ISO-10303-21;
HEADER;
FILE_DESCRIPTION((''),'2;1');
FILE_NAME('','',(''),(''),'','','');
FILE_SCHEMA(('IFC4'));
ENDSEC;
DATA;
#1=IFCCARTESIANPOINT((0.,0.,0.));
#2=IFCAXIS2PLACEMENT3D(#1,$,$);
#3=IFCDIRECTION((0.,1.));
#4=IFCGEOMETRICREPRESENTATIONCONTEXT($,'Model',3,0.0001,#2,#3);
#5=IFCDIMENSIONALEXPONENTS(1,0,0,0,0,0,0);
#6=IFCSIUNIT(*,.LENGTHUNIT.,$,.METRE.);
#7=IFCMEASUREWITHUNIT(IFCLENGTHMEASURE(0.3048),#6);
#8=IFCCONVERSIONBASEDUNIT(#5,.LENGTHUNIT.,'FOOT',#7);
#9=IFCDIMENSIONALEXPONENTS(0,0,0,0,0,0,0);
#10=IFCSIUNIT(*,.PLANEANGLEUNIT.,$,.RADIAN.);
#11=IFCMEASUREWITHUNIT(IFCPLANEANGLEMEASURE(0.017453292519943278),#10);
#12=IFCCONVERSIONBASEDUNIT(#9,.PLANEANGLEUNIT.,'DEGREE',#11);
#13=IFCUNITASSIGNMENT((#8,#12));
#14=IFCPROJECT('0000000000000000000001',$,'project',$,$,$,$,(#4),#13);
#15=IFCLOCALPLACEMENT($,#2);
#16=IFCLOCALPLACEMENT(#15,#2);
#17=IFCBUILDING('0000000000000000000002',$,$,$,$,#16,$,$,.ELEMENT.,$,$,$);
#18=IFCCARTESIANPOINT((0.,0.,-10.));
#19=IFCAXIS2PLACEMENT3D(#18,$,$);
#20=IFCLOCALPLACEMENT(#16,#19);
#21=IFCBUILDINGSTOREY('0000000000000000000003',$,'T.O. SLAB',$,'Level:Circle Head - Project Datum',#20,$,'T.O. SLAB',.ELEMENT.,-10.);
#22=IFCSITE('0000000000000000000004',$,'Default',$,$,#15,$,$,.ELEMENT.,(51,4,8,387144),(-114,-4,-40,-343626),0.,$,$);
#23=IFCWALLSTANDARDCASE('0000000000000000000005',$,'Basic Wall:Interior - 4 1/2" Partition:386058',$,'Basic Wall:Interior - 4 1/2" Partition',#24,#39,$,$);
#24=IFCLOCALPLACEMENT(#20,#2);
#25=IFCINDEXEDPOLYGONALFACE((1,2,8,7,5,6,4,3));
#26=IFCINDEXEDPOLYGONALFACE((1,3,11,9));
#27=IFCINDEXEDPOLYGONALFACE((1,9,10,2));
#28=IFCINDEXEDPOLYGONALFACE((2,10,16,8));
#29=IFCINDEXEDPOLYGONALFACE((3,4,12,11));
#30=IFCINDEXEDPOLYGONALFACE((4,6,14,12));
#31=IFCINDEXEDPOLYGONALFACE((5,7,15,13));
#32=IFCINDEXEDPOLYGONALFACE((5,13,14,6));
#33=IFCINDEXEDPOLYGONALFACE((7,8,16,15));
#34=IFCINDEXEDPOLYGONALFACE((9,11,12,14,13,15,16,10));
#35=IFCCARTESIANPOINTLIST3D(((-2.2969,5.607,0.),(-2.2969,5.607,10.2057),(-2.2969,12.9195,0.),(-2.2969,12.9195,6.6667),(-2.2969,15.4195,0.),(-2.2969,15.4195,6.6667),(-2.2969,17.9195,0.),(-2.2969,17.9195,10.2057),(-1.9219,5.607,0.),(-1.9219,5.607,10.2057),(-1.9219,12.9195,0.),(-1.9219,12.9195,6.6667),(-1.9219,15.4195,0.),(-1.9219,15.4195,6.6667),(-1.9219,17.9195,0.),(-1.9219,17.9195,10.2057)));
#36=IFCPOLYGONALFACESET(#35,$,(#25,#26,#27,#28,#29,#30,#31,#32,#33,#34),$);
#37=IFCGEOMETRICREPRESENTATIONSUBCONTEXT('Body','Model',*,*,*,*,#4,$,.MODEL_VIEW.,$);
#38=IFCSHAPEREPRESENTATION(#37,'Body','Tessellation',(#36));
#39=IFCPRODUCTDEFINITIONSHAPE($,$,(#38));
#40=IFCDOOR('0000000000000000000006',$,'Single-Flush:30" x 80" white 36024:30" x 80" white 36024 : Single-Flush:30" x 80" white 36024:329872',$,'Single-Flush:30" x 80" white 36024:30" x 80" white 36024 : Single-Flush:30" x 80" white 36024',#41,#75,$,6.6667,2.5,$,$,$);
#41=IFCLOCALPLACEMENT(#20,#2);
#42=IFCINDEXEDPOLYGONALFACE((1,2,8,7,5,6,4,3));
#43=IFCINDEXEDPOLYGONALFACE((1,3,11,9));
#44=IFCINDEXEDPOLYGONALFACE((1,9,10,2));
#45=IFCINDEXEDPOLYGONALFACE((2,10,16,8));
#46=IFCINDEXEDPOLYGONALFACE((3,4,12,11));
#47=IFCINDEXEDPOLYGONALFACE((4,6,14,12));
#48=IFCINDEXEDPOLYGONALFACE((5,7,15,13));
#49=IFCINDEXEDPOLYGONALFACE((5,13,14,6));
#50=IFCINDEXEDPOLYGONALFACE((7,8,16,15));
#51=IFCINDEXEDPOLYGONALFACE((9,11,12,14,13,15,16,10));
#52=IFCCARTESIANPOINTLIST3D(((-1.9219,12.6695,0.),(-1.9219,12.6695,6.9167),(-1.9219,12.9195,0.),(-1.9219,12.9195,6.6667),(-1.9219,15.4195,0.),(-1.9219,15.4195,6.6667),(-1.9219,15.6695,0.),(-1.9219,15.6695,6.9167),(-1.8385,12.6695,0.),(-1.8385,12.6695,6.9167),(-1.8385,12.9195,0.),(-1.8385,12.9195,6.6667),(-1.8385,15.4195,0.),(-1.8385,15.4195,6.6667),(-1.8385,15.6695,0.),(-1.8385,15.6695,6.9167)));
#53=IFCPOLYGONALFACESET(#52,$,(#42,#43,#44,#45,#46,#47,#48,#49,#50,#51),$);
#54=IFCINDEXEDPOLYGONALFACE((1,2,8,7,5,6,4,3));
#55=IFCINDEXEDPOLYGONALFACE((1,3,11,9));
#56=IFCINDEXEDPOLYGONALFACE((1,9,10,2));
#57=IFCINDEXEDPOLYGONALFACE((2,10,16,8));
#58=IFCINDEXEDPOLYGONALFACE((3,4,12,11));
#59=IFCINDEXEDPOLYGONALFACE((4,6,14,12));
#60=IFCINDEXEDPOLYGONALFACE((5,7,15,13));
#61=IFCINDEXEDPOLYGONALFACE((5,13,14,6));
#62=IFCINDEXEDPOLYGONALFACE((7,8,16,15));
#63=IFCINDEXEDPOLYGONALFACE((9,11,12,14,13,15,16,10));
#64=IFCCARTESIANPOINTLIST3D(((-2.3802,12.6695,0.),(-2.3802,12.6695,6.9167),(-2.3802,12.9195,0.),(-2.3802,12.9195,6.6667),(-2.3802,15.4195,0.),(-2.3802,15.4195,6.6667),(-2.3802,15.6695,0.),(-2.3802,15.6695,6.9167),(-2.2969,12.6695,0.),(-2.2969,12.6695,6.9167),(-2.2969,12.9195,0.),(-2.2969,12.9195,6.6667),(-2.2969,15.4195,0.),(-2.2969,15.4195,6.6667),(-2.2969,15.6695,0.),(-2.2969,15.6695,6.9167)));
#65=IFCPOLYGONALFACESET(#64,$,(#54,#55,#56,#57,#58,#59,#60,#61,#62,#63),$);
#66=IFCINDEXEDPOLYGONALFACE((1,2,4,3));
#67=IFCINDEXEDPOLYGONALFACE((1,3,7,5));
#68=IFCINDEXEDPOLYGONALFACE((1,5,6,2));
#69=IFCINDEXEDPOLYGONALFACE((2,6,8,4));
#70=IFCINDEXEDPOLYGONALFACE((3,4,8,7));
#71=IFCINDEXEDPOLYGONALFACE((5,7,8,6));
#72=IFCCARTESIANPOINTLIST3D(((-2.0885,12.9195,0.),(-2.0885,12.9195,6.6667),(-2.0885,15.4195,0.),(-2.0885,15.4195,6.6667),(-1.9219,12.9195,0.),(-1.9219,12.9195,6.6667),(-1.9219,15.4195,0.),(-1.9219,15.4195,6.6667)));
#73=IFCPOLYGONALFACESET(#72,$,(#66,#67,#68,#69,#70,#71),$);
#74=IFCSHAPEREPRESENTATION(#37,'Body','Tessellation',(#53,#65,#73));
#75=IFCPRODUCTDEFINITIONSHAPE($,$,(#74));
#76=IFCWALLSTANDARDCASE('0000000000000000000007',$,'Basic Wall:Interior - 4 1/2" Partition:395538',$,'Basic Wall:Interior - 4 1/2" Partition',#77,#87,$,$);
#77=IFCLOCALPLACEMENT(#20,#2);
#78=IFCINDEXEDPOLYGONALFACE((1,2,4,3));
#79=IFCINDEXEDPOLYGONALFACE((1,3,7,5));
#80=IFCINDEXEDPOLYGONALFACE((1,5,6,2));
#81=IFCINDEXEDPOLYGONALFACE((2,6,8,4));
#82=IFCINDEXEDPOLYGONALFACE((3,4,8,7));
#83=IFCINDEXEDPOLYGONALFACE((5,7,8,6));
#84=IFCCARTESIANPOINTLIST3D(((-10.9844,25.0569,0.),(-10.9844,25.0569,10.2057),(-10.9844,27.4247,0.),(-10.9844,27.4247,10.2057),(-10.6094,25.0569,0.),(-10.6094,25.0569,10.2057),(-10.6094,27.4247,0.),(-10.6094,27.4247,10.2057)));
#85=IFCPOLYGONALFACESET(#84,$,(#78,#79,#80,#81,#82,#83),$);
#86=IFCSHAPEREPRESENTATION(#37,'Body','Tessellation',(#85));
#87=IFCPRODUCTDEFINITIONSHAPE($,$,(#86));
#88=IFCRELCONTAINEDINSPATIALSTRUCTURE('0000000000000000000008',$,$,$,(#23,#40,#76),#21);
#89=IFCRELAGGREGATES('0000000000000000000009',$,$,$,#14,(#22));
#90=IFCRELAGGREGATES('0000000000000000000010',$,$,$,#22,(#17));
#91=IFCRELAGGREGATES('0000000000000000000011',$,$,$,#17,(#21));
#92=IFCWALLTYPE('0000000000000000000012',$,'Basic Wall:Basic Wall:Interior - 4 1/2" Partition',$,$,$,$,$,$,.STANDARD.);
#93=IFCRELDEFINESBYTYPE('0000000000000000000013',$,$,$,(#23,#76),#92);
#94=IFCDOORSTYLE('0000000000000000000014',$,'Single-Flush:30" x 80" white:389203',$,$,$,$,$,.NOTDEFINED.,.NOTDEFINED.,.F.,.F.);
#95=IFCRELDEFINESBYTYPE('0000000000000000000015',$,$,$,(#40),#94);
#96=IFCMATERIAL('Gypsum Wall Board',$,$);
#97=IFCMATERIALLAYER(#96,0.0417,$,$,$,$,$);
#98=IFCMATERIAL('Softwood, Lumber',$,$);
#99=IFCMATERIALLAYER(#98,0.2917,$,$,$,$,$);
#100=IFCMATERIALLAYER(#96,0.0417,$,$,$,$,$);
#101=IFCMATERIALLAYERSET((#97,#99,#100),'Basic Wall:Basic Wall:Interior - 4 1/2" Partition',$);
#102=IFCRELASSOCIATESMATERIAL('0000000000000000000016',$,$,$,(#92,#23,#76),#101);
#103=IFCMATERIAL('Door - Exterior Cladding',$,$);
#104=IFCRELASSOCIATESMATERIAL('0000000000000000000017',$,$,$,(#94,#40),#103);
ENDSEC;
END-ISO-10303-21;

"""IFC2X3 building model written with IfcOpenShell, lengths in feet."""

from ifc_helpers import new_model, entity, si_unit, converted_unit, direction, frame, frame_2d, origin, origin_2d_with_axis, place, context, subcontext, project, spatial, polyline, rectangle, outline, extrude, source, transform, mapped, material, layer, layer_set, layer_usage, type_object, type_shapes, element, fill, save


model = new_model("IFC2X3")

# Units and contexts
model_context = context("Model", 3, precision=0.0001, world=origin(), true_north=direction((0.0, 1.0)))
body_context = subcontext(model_context, "Body", "Model", "MODEL_VIEW")
ifc_project = project(units=[converted_unit("LENGTHUNIT", "FOOT", entity("IfcLengthMeasure", 0.3048), si_unit("LENGTHUNIT", "METRE"), dimensions=[1, 0, 0, 0, 0, 0, 0]), converted_unit("PLANEANGLEUNIT", "DEGREE", entity("IfcPlaneAngleMeasure", 0.017453292519943278), si_unit("PLANEANGLEUNIT", "RADIAN"), dimensions=[0, 0, 0, 0, 0, 0, 0])], contexts=[model_context])

# Site, building, storey
site_placement = place(None, origin())
site = spatial("IfcSite", under=ifc_project, at=site_placement, Name="Default", CompositionType="ELEMENT", RefLatitude=(51, 4, 8, 387144), RefLongitude=(-114, -4, -40, -343626), RefElevation=0.0)
building_placement = place(site_placement, origin())
building = spatial("IfcBuilding", under=site, at=building_placement, CompositionType="ELEMENT")
storey_placement = place(building_placement, frame((0.0, 0.0, -10.0)))
storey = spatial("IfcBuildingStorey", under=building, at=storey_placement, Name="T.O. SLAB", ObjectType="Level:Circle Head - Project Datum", LongName="T.O. SLAB", CompositionType="ELEMENT", Elevation=-10.0)

# Shared definitions
ifc_material_1 = material(Name="Gypsum Wall Board")
ifc_layer_1 = layer(ifc_material_1, 0.0417)
ifc_material_2 = material(Name="Softwood, Lumber")
ifc_layer_2 = layer(ifc_material_2, 0.2917)
ifc_layer_3 = layer(ifc_material_1, 0.0417)
ifc_layer_set_1 = layer_set([ifc_layer_1, ifc_layer_2, ifc_layer_3], Name="Basic Wall:Basic Wall:Interior - 4 1/2\" Partition")
wall_type_1 = type_object("IfcWallType", Name="Basic Wall:Basic Wall:Interior - 4 1/2\" Partition", PredefinedType="STANDARD", material=ifc_layer_set_1)
ifc_material_3 = material(Name="Door - Exterior Cladding")

# Wall, opening, door
ifc_layer_usage_1 = layer_usage(ifc_layer_set_1, "AXIS2", "NEGATIVE", 0.1875)
wall_1_placement = place(storey_placement, frame((-2.1094, 17.9195, 0.0), z_axis=(0.0, 0.0, 1.0), x_axis=(0.0, -1.0, 0.0)))
wall_1 = element("IfcWallStandardCase", 1, at=wall_1_placement, inside=storey, type_object=wall_type_1, material=ifc_layer_usage_1, Name="Basic Wall:Interior - 4 1/2\" Partition:386058", ObjectType="Basic Wall:Interior - 4 1/2\" Partition", context=body_context, shape_type="SweptSolid", body=[
    extrude(rectangle(XDim=12.3125, YDim=0.375, at=frame_2d((6.1562, 0.0), x_axis=(1.0, 0.0))), origin(), (0.0, 0.0, 1.0), 10.2057),
])
opening_1_placement = place(wall_1_placement, frame((17.9195, 2.1094, 0.0), z_axis=(0.0, 0.0, 1.0), x_axis=(0.0, 1.0, 0.0)))
opening_1 = element("IfcOpeningElement", 2, at=opening_1_placement, cuts=wall_1, ObjectType="Opening", context=body_context, shape_type="SweptSolid", body=[
    extrude(rectangle(XDim=6.6667, YDim=2.5, at=origin_2d_with_axis()), frame((-2.3006, 14.1695, 3.3333), z_axis=(1.0, 0.0, 0.0), x_axis=(0.0, 0.0, 1.0)), (0.0, 0.0, 1.0), 0.3825),
])
door_style_1 = type_object("IfcDoorStyle", Name="Single-Flush:30\" x 80\" white:389203", ConstructionType="NOTDEFINED", OperationType="NOTDEFINED", ParameterTakesPrecedence=False, Sizeable=False, material=ifc_material_3)
shared_shape_1 = source(origin(), body_context, "Body", "SweptSolid", [
    extrude(outline(polyline([(-1.5, -3.5208), (1.5, -3.5208), (1.5, 3.3958), (1.25, 3.3958), (1.25, -3.2708), (-1.25, -3.2708), (-1.25, 3.3958), (-1.5, 3.3958), (-1.5, -3.5208)])), frame((1.25, -0.0038, 3.3958), z_axis=(0.0, 1.0, 0.0), x_axis=(1.0, 0.0, 0.0)), (0.0, 0.0, 1.0), 0.0833),
    extrude(outline(polyline([(-3.3958, -1.5), (3.5208, -1.5), (3.5208, 1.5), (-3.3958, 1.5), (-3.3958, 1.25), (3.2708, 1.25), (3.2708, -1.25), (-3.3958, -1.25), (-3.3958, -1.5)])), frame((1.25, -0.4621, 3.3958), z_axis=(0.0, 1.0, 0.0), x_axis=(0.0, 0.0, 1.0)), (0.0, 0.0, 1.0), 0.0833),
    extrude(rectangle(XDim=0.1667, YDim=2.5, at=origin_2d_with_axis()), frame((1.25, -0.0871, 0.0), z_axis=(0.0, 0.0, 1.0), x_axis=(0.0, 1.0, 0.0)), (0.0, 0.0, 1.0), 6.6667),
])
type_shapes(door_style_1, [shared_shape_1])
door_1_placement = place(opening_1_placement, frame((-1.9181, 15.4195, 0.0), z_axis=(0.0, 0.0, 1.0), x_axis=(0.0, -1.0, 0.0)))
door_1 = element("IfcDoor", 3, at=door_1_placement, inside=storey, type_object=door_style_1, material=ifc_material_3, Name="Single-Flush:30\" x 80\" white 36024:30\" x 80\" white 36024 : Single-Flush:30\" x 80\" white 36024:329872", ObjectType="Single-Flush:30\" x 80\" white 36024:30\" x 80\" white 36024 : Single-Flush:30\" x 80\" white 36024", OverallHeight=6.6667, OverallWidth=2.5, context=body_context, shape_type="MappedRepresentation", body=[
    mapped(shared_shape_1, transform((0.0, 0.0, 0.0), scale=1.0)),
])
fill(opening_1, door_1)

# Wall
ifc_layer_usage_2 = layer_usage(ifc_layer_set_1, "AXIS2", "NEGATIVE", 0.1875)
wall_2_placement = place(storey_placement, frame((-10.7969, 25.0569, 0.0), z_axis=(0.0, 0.0, 1.0), x_axis=(0.0, 1.0, 0.0)))
element("IfcWallStandardCase", 4, at=wall_2_placement, inside=storey, type_object=wall_type_1, material=ifc_layer_usage_2, Name="Basic Wall:Interior - 4 1/2\" Partition:395538", ObjectType="Basic Wall:Interior - 4 1/2\" Partition", context=body_context, shape_type="SweptSolid", body=[
    extrude(rectangle(XDim=2.3678, YDim=0.375, at=frame_2d((1.1839, 0.0), x_axis=(-1.0, 0.0))), origin(), (0.0, 0.0, 1.0), 10.2057),
])

save(model, "model.ifc")
